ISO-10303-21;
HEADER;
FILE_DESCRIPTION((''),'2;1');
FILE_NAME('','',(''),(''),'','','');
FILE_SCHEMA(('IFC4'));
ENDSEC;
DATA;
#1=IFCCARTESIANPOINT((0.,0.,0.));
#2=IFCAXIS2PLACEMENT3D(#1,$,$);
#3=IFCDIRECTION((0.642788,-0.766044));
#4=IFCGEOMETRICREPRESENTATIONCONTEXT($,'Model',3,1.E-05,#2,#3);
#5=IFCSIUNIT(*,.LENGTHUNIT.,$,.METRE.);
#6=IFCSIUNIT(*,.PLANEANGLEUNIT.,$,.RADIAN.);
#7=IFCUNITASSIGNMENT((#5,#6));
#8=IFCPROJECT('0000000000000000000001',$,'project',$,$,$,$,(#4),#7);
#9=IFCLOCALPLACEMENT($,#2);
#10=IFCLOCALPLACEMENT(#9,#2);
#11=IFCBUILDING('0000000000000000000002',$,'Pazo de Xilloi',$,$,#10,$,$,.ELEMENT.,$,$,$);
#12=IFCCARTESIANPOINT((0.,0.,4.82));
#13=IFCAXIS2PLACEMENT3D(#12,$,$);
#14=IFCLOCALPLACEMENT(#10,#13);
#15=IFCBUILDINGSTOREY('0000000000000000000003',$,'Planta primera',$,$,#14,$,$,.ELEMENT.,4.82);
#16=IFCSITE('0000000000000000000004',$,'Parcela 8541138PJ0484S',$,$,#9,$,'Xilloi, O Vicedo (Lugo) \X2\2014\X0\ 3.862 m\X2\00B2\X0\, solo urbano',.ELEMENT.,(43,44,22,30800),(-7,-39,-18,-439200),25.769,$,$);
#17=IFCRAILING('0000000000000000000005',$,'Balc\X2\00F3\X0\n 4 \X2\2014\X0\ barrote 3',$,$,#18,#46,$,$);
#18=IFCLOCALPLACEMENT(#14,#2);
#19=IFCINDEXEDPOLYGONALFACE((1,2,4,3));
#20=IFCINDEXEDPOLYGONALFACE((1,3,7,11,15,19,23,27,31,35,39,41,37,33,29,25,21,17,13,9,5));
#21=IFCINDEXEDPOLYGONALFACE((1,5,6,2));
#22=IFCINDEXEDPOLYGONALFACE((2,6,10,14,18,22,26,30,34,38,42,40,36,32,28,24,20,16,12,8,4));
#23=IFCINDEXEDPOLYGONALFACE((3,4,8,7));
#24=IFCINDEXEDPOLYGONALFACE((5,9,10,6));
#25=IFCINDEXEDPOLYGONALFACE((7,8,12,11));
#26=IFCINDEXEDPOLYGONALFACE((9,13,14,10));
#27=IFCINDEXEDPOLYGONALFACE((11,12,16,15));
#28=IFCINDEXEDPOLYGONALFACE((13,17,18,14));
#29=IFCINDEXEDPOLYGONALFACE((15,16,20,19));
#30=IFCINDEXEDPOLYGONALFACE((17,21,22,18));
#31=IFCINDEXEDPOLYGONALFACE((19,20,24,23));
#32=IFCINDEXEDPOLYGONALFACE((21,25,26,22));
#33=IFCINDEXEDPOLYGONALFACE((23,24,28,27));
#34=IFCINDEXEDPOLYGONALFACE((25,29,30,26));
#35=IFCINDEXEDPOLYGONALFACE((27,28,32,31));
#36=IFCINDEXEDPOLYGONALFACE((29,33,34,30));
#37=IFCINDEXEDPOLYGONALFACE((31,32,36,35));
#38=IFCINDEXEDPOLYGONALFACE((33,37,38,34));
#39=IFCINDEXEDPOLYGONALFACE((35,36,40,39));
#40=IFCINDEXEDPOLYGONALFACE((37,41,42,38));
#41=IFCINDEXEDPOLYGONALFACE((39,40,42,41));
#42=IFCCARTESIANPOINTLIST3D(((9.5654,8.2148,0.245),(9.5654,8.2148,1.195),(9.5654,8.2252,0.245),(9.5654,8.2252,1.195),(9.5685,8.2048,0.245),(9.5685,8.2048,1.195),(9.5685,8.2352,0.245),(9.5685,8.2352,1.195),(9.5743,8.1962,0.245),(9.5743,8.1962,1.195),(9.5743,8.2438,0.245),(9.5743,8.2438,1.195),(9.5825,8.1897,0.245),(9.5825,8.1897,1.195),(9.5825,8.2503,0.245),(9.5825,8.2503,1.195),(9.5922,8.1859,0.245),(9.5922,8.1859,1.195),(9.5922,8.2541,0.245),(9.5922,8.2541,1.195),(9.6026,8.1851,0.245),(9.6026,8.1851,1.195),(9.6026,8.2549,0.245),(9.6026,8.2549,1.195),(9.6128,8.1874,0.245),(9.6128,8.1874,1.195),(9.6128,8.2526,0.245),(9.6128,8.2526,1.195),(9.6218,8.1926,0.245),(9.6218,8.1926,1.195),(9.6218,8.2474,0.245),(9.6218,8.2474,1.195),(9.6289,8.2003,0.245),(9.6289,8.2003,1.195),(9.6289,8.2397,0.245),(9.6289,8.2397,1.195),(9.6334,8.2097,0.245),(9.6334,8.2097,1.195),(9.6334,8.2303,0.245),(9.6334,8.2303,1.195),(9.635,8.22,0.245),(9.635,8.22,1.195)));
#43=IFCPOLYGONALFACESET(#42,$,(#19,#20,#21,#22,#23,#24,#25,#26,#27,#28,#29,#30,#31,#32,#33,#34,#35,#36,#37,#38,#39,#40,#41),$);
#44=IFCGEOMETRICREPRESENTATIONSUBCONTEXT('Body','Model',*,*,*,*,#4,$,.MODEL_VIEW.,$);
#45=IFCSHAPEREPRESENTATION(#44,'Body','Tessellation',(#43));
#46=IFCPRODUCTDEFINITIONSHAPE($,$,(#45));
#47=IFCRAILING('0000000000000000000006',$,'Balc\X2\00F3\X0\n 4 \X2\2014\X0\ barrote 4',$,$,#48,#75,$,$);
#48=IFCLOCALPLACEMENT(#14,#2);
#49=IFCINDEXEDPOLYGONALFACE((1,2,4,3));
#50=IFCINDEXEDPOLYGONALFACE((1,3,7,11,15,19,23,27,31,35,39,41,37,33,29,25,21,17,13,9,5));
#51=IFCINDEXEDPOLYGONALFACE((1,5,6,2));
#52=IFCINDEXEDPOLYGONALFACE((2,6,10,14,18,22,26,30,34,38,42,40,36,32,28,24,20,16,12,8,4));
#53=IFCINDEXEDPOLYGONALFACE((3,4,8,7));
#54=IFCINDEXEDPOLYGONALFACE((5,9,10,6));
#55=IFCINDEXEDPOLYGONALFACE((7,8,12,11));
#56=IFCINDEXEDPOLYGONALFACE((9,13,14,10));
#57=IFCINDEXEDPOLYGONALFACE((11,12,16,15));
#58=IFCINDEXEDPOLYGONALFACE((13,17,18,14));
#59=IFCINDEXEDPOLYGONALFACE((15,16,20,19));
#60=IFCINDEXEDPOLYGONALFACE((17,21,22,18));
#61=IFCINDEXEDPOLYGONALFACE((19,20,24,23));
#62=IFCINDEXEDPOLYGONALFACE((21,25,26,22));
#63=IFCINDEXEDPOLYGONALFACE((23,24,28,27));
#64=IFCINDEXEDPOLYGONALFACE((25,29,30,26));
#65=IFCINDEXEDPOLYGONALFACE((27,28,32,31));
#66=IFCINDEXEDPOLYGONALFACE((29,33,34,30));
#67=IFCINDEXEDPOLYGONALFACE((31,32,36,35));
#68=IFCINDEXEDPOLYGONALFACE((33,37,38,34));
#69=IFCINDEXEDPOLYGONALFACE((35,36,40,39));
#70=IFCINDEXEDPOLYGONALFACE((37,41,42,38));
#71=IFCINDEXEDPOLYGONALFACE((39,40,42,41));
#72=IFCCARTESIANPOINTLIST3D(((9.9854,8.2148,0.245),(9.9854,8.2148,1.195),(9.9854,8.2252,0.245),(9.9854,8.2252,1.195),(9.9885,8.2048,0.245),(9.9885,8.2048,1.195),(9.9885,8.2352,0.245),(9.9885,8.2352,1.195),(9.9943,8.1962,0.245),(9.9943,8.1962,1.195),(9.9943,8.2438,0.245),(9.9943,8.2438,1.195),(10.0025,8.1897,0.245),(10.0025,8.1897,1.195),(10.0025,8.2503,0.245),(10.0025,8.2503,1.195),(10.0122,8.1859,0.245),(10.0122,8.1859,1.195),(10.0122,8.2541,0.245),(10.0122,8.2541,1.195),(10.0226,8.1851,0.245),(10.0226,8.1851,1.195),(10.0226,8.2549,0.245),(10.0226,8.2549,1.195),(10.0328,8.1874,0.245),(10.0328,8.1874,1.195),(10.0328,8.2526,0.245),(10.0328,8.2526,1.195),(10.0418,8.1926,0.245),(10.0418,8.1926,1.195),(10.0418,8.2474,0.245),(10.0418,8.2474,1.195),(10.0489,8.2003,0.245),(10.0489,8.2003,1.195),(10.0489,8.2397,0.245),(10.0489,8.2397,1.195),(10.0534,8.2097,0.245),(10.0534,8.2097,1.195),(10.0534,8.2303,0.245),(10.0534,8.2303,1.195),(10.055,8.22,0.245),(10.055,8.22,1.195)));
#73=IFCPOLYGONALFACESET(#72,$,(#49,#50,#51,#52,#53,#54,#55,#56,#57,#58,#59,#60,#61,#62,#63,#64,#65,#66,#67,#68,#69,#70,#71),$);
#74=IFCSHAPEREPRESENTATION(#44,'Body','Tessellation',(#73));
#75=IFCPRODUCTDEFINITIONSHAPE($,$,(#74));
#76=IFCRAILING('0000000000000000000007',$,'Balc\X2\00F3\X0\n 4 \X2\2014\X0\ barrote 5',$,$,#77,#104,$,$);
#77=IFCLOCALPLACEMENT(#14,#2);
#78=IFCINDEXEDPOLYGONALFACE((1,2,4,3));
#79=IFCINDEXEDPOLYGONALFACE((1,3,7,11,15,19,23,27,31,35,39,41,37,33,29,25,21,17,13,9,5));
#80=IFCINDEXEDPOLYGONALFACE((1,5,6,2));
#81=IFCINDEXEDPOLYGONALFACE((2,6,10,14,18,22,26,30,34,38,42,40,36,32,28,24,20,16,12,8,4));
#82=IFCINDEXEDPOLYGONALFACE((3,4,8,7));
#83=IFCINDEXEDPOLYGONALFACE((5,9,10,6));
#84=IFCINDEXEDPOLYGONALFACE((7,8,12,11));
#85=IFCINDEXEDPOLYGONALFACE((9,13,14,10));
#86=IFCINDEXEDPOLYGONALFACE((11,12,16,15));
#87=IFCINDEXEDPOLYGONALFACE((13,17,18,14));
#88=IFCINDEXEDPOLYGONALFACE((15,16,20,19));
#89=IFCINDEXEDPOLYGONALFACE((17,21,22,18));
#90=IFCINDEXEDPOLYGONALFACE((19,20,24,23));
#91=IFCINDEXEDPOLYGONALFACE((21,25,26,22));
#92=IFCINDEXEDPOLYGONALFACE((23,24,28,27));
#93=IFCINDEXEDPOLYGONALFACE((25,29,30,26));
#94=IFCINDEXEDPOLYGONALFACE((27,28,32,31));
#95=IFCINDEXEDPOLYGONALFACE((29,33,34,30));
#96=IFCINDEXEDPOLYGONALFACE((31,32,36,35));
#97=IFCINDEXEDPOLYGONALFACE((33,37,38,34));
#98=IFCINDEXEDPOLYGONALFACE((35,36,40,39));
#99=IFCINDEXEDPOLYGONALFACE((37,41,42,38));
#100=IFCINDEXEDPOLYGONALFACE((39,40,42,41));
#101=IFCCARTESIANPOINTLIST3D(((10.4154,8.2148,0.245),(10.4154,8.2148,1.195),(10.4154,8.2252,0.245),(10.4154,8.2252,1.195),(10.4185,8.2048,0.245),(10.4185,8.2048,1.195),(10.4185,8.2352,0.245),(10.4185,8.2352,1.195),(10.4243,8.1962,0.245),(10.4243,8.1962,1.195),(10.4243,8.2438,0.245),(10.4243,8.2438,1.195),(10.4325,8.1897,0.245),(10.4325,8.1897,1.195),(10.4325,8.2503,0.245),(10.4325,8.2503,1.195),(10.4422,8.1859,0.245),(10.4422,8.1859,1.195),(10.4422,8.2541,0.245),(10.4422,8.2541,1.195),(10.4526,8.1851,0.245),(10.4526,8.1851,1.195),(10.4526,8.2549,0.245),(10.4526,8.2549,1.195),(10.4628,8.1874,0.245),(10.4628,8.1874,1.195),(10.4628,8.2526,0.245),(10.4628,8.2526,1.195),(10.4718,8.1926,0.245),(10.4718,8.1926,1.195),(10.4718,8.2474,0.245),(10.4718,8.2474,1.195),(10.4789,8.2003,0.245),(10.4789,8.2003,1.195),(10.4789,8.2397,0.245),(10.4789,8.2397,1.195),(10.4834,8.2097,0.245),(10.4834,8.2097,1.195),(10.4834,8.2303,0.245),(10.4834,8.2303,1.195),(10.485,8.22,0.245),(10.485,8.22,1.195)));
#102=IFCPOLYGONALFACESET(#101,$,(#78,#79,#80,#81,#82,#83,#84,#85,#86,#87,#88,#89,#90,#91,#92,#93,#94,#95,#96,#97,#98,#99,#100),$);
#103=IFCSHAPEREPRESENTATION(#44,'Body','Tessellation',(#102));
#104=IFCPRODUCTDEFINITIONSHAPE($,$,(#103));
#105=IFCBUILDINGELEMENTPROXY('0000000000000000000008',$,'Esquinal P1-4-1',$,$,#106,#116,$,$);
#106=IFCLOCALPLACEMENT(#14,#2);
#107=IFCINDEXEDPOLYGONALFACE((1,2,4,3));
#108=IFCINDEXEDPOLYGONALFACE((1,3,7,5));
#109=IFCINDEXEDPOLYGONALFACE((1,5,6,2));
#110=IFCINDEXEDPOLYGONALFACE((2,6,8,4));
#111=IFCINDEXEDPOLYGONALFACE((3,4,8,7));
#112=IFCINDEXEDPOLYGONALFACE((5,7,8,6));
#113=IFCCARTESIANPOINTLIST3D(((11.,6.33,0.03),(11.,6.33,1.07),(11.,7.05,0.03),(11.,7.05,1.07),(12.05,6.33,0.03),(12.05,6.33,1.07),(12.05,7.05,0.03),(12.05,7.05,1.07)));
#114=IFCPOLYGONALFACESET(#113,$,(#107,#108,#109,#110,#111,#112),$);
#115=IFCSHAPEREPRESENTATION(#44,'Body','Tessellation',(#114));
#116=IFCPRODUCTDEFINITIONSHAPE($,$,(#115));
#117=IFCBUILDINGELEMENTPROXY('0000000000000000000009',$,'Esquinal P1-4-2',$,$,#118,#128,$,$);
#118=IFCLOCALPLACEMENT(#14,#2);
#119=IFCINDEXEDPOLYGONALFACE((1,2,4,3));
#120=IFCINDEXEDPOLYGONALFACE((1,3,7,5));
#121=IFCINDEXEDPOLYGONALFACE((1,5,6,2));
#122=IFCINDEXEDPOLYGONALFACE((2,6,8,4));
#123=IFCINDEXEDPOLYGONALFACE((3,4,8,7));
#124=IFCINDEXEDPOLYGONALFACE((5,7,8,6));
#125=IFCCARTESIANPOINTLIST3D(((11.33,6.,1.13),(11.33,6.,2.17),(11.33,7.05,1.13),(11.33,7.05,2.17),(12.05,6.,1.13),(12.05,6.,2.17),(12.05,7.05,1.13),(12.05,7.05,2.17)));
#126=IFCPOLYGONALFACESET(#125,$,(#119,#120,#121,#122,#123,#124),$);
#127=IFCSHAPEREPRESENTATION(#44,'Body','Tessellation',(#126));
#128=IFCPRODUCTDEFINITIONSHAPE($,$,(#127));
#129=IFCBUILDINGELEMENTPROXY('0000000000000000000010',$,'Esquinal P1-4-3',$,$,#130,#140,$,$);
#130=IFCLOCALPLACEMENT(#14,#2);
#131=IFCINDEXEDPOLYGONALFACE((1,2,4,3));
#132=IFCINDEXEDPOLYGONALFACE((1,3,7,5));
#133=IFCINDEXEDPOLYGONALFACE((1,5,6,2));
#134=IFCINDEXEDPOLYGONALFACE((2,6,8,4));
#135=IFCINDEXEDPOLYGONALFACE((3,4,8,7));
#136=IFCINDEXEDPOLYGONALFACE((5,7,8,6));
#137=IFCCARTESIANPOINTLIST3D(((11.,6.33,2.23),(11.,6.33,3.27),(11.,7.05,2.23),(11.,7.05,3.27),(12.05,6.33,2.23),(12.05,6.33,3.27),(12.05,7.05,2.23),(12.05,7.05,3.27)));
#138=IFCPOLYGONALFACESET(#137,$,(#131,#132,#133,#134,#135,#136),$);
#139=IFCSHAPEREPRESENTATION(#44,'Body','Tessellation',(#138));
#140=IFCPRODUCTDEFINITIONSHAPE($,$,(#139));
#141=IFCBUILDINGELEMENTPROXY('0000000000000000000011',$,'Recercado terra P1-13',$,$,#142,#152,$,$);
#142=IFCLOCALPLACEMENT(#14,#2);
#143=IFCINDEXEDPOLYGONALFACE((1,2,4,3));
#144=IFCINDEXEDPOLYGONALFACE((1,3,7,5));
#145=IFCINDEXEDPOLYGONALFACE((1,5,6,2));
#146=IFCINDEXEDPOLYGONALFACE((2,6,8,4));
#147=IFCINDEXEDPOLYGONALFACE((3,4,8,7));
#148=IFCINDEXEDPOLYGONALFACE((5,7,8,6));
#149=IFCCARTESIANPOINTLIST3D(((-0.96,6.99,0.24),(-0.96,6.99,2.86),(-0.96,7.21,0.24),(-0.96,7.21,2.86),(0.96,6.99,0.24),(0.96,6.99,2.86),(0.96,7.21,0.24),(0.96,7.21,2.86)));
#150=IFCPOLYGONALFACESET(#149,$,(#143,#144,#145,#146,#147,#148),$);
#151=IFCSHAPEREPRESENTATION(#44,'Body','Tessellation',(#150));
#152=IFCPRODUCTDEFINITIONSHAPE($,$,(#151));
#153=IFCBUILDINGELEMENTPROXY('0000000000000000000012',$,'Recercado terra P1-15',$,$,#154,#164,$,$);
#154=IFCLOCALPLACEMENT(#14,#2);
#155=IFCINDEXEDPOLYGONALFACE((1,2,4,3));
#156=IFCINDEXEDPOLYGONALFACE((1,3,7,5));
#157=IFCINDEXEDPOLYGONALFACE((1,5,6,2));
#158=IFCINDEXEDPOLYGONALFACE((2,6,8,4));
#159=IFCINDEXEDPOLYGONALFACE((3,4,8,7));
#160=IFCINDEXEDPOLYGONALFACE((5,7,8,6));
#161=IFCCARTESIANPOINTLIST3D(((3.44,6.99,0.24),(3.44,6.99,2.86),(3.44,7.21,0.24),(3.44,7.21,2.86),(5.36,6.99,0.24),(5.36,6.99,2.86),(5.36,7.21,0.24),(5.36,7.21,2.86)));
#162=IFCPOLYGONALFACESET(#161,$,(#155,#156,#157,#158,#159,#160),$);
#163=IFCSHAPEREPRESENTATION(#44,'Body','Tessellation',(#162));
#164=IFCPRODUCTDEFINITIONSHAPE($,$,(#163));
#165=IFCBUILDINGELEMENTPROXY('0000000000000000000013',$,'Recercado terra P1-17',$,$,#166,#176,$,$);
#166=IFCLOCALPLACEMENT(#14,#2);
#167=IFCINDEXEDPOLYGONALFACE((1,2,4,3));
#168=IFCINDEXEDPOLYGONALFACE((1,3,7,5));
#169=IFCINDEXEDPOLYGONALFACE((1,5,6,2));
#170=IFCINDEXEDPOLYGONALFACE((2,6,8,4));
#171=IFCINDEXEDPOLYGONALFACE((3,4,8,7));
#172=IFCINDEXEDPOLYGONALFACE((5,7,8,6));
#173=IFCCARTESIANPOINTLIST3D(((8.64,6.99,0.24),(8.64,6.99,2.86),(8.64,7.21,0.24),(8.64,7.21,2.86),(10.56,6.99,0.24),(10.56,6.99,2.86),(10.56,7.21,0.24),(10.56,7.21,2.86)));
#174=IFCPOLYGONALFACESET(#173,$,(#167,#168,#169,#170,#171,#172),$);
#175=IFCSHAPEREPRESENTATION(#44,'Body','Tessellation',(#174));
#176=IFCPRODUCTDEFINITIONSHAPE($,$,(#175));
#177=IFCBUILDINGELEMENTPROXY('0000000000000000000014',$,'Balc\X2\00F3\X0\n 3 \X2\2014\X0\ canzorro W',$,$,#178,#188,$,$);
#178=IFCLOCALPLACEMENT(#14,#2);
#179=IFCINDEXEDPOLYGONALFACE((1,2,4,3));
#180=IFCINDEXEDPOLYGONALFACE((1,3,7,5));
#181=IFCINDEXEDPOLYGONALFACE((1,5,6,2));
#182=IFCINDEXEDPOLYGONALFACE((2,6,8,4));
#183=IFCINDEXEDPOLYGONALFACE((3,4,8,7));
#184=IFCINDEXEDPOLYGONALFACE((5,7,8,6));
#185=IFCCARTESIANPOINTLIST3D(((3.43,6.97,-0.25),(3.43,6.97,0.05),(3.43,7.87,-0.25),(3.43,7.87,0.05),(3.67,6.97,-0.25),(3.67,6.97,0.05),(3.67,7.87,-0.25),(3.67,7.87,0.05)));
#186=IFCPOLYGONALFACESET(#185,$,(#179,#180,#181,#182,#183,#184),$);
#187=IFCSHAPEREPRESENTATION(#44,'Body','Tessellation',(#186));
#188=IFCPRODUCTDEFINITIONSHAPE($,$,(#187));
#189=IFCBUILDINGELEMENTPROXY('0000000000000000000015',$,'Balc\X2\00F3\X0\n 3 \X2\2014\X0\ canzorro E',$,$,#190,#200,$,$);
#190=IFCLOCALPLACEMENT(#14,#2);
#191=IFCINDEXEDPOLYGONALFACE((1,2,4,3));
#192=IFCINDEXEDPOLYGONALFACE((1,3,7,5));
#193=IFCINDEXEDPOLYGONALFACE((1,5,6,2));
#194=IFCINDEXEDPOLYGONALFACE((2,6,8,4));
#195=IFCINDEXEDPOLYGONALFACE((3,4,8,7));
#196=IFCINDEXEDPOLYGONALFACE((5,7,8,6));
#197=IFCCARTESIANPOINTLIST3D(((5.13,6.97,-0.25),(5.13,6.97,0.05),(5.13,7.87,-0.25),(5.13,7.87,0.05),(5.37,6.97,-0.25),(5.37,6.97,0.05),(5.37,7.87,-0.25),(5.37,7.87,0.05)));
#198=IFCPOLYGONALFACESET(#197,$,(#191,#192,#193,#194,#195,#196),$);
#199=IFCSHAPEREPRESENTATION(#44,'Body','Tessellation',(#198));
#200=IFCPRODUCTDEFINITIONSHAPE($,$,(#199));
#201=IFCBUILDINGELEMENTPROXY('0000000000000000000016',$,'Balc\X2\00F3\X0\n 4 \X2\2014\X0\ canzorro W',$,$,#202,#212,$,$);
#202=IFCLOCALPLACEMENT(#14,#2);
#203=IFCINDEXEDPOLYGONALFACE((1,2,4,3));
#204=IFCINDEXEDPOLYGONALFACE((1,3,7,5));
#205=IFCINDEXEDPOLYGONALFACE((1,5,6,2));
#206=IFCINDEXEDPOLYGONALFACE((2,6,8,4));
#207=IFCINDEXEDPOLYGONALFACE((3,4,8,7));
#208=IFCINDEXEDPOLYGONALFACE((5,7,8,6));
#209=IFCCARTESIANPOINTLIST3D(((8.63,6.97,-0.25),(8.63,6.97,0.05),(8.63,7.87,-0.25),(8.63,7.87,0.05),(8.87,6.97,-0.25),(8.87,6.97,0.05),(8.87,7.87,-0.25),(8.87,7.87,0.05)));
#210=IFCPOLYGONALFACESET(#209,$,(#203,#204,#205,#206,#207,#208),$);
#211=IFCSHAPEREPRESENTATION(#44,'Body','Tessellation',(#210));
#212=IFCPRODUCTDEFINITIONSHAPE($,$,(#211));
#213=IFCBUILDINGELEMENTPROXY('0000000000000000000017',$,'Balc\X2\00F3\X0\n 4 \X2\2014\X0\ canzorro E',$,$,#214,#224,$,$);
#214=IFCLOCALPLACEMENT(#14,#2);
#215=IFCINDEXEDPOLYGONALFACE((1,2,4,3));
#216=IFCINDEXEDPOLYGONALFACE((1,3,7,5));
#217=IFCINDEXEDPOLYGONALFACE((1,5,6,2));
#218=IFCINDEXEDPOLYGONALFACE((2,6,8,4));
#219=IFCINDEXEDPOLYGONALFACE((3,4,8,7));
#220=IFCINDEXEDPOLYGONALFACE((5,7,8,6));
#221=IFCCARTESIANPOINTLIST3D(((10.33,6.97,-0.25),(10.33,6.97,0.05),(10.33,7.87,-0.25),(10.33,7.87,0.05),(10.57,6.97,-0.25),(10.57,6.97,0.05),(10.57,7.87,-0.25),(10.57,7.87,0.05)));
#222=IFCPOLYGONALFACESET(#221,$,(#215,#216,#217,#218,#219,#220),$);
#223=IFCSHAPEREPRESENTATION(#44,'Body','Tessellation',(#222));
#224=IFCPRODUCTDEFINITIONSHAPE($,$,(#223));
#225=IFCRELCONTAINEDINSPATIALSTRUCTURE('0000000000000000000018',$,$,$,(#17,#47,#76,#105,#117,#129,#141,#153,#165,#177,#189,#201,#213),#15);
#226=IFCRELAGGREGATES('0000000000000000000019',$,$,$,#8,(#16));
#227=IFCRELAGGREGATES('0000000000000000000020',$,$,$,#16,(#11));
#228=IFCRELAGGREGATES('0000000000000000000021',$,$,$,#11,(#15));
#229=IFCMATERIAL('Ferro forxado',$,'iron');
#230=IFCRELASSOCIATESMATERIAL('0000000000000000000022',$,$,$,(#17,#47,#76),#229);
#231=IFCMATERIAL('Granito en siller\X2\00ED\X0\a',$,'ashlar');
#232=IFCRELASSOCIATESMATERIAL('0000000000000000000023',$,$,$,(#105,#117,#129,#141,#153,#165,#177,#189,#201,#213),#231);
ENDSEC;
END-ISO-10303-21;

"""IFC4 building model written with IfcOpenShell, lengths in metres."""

from ifc_helpers import new_model, si_unit, direction, frame, origin, origin_2d, place, context, subcontext, project, spatial, rectangle, circle, extrude, material, element, save


model = new_model("IFC4")

# Units and contexts
model_context = context("Model", 3, precision=1e-05, world=origin(), true_north=direction((0.642788, -0.766044)))
body_context = subcontext(model_context, "Body", "Model", "MODEL_VIEW")
ifc_project = project(units=[si_unit("LENGTHUNIT", "METRE"), si_unit("PLANEANGLEUNIT", "RADIAN")], contexts=[model_context])

# Site, building, storey
site_placement = place(None, origin())
site = spatial("IfcSite", under=ifc_project, at=site_placement, Name="Parcela 8541138PJ0484S", LongName="Xilloi, O Vicedo (Lugo) — 3.862 m², solo urbano", CompositionType="ELEMENT", RefLatitude=(43, 44, 22, 30800), RefLongitude=(-7, -39, -18, -439200), RefElevation=25.769)
building_placement = place(site_placement, origin())
building = spatial("IfcBuilding", under=site, at=building_placement, Name="Pazo de Xilloi", CompositionType="ELEMENT")
storey_placement = place(building_placement, frame((0.0, 0.0, 4.82)))
storey = spatial("IfcBuildingStorey", under=building, at=storey_placement, Name="Planta primera", CompositionType="ELEMENT", Elevation=4.82)

# Shared definitions
ifc_material_1 = material(Name="Granito en sillería", Category="ashlar")

# Railings
ifc_material_2 = material(Name="Ferro forxado", Category="iron")
for number, where, name in (
    (1, (9.6, 8.22, 0.72), "Balcón 4 — barrote 3"),
    (2, (10.02, 8.22, 0.72), "Balcón 4 — barrote 4"),
    (3, (10.45, 8.22, 0.72), "Balcón 4 — barrote 5"),
):
    element("IfcRailing", number, at=place(storey_placement, frame(where)), inside=storey, material=ifc_material_2, Name=name, context=body_context, shape_type="SweptSolid", body=[
        extrude(circle(Radius=0.035, at=origin_2d()), frame((0.0, 0.0, -0.475)), (0.0, 0.0, 1.0), 0.95),
    ])

# Building element proxies
proxy_1_placement = place(storey_placement, frame((11.525, 6.69, 0.55)))
element("IfcBuildingElementProxy", 4, at=proxy_1_placement, inside=storey, material=ifc_material_1, Name="Esquinal P1-4-1", context=body_context, shape_type="SweptSolid", body=[
    extrude(rectangle(XDim=1.05, YDim=0.72, at=origin_2d()), frame((0.0, 0.0, -0.52)), (0.0, 0.0, 1.0), 1.04),
])
proxy_2_placement = place(storey_placement, frame((11.69, 6.525, 1.65)))
element("IfcBuildingElementProxy", 5, at=proxy_2_placement, inside=storey, material=ifc_material_1, Name="Esquinal P1-4-2", context=body_context, shape_type="SweptSolid", body=[
    extrude(rectangle(XDim=0.72, YDim=1.05, at=origin_2d()), frame((0.0, 0.0, -0.52)), (0.0, 0.0, 1.0), 1.04),
])
proxy_3_placement = place(storey_placement, frame((11.525, 6.69, 2.75)))
element("IfcBuildingElementProxy", 6, at=proxy_3_placement, inside=storey, material=ifc_material_1, Name="Esquinal P1-4-3", context=body_context, shape_type="SweptSolid", body=[
    extrude(rectangle(XDim=1.05, YDim=0.72, at=origin_2d()), frame((0.0, 0.0, -0.52)), (0.0, 0.0, 1.0), 1.04),
])
for number, where, name in (
    (7, (0.0, 7.1, 1.55), "Recercado terra P1-13"),
    (8, (4.4, 7.1, 1.55), "Recercado terra P1-15"),
    (9, (9.6, 7.1, 1.55), "Recercado terra P1-17"),
):
    element("IfcBuildingElementProxy", number, at=place(storey_placement, frame(where)), inside=storey, material=ifc_material_1, Name=name, context=body_context, shape_type="SweptSolid", body=[
        extrude(rectangle(XDim=1.92, YDim=0.22, at=origin_2d()), frame((0.0, 0.0, -1.31)), (0.0, 0.0, 1.0), 2.62),
    ])
for number, where, name in (
    (10, (3.55, 7.42, -0.1), "Balcón 3 — canzorro W"),
    (11, (5.25, 7.42, -0.1), "Balcón 3 — canzorro E"),
    (12, (8.75, 7.42, -0.1), "Balcón 4 — canzorro W"),
    (13, (10.45, 7.42, -0.1), "Balcón 4 — canzorro E"),
):
    element("IfcBuildingElementProxy", number, at=place(storey_placement, frame(where)), inside=storey, material=ifc_material_1, Name=name, context=body_context, shape_type="SweptSolid", body=[
        extrude(rectangle(XDim=0.24, YDim=0.9, at=origin_2d()), frame((0.0, 0.0, -0.15)), (0.0, 0.0, 1.0), 0.3),
    ])

save(model, "model.ifc")
